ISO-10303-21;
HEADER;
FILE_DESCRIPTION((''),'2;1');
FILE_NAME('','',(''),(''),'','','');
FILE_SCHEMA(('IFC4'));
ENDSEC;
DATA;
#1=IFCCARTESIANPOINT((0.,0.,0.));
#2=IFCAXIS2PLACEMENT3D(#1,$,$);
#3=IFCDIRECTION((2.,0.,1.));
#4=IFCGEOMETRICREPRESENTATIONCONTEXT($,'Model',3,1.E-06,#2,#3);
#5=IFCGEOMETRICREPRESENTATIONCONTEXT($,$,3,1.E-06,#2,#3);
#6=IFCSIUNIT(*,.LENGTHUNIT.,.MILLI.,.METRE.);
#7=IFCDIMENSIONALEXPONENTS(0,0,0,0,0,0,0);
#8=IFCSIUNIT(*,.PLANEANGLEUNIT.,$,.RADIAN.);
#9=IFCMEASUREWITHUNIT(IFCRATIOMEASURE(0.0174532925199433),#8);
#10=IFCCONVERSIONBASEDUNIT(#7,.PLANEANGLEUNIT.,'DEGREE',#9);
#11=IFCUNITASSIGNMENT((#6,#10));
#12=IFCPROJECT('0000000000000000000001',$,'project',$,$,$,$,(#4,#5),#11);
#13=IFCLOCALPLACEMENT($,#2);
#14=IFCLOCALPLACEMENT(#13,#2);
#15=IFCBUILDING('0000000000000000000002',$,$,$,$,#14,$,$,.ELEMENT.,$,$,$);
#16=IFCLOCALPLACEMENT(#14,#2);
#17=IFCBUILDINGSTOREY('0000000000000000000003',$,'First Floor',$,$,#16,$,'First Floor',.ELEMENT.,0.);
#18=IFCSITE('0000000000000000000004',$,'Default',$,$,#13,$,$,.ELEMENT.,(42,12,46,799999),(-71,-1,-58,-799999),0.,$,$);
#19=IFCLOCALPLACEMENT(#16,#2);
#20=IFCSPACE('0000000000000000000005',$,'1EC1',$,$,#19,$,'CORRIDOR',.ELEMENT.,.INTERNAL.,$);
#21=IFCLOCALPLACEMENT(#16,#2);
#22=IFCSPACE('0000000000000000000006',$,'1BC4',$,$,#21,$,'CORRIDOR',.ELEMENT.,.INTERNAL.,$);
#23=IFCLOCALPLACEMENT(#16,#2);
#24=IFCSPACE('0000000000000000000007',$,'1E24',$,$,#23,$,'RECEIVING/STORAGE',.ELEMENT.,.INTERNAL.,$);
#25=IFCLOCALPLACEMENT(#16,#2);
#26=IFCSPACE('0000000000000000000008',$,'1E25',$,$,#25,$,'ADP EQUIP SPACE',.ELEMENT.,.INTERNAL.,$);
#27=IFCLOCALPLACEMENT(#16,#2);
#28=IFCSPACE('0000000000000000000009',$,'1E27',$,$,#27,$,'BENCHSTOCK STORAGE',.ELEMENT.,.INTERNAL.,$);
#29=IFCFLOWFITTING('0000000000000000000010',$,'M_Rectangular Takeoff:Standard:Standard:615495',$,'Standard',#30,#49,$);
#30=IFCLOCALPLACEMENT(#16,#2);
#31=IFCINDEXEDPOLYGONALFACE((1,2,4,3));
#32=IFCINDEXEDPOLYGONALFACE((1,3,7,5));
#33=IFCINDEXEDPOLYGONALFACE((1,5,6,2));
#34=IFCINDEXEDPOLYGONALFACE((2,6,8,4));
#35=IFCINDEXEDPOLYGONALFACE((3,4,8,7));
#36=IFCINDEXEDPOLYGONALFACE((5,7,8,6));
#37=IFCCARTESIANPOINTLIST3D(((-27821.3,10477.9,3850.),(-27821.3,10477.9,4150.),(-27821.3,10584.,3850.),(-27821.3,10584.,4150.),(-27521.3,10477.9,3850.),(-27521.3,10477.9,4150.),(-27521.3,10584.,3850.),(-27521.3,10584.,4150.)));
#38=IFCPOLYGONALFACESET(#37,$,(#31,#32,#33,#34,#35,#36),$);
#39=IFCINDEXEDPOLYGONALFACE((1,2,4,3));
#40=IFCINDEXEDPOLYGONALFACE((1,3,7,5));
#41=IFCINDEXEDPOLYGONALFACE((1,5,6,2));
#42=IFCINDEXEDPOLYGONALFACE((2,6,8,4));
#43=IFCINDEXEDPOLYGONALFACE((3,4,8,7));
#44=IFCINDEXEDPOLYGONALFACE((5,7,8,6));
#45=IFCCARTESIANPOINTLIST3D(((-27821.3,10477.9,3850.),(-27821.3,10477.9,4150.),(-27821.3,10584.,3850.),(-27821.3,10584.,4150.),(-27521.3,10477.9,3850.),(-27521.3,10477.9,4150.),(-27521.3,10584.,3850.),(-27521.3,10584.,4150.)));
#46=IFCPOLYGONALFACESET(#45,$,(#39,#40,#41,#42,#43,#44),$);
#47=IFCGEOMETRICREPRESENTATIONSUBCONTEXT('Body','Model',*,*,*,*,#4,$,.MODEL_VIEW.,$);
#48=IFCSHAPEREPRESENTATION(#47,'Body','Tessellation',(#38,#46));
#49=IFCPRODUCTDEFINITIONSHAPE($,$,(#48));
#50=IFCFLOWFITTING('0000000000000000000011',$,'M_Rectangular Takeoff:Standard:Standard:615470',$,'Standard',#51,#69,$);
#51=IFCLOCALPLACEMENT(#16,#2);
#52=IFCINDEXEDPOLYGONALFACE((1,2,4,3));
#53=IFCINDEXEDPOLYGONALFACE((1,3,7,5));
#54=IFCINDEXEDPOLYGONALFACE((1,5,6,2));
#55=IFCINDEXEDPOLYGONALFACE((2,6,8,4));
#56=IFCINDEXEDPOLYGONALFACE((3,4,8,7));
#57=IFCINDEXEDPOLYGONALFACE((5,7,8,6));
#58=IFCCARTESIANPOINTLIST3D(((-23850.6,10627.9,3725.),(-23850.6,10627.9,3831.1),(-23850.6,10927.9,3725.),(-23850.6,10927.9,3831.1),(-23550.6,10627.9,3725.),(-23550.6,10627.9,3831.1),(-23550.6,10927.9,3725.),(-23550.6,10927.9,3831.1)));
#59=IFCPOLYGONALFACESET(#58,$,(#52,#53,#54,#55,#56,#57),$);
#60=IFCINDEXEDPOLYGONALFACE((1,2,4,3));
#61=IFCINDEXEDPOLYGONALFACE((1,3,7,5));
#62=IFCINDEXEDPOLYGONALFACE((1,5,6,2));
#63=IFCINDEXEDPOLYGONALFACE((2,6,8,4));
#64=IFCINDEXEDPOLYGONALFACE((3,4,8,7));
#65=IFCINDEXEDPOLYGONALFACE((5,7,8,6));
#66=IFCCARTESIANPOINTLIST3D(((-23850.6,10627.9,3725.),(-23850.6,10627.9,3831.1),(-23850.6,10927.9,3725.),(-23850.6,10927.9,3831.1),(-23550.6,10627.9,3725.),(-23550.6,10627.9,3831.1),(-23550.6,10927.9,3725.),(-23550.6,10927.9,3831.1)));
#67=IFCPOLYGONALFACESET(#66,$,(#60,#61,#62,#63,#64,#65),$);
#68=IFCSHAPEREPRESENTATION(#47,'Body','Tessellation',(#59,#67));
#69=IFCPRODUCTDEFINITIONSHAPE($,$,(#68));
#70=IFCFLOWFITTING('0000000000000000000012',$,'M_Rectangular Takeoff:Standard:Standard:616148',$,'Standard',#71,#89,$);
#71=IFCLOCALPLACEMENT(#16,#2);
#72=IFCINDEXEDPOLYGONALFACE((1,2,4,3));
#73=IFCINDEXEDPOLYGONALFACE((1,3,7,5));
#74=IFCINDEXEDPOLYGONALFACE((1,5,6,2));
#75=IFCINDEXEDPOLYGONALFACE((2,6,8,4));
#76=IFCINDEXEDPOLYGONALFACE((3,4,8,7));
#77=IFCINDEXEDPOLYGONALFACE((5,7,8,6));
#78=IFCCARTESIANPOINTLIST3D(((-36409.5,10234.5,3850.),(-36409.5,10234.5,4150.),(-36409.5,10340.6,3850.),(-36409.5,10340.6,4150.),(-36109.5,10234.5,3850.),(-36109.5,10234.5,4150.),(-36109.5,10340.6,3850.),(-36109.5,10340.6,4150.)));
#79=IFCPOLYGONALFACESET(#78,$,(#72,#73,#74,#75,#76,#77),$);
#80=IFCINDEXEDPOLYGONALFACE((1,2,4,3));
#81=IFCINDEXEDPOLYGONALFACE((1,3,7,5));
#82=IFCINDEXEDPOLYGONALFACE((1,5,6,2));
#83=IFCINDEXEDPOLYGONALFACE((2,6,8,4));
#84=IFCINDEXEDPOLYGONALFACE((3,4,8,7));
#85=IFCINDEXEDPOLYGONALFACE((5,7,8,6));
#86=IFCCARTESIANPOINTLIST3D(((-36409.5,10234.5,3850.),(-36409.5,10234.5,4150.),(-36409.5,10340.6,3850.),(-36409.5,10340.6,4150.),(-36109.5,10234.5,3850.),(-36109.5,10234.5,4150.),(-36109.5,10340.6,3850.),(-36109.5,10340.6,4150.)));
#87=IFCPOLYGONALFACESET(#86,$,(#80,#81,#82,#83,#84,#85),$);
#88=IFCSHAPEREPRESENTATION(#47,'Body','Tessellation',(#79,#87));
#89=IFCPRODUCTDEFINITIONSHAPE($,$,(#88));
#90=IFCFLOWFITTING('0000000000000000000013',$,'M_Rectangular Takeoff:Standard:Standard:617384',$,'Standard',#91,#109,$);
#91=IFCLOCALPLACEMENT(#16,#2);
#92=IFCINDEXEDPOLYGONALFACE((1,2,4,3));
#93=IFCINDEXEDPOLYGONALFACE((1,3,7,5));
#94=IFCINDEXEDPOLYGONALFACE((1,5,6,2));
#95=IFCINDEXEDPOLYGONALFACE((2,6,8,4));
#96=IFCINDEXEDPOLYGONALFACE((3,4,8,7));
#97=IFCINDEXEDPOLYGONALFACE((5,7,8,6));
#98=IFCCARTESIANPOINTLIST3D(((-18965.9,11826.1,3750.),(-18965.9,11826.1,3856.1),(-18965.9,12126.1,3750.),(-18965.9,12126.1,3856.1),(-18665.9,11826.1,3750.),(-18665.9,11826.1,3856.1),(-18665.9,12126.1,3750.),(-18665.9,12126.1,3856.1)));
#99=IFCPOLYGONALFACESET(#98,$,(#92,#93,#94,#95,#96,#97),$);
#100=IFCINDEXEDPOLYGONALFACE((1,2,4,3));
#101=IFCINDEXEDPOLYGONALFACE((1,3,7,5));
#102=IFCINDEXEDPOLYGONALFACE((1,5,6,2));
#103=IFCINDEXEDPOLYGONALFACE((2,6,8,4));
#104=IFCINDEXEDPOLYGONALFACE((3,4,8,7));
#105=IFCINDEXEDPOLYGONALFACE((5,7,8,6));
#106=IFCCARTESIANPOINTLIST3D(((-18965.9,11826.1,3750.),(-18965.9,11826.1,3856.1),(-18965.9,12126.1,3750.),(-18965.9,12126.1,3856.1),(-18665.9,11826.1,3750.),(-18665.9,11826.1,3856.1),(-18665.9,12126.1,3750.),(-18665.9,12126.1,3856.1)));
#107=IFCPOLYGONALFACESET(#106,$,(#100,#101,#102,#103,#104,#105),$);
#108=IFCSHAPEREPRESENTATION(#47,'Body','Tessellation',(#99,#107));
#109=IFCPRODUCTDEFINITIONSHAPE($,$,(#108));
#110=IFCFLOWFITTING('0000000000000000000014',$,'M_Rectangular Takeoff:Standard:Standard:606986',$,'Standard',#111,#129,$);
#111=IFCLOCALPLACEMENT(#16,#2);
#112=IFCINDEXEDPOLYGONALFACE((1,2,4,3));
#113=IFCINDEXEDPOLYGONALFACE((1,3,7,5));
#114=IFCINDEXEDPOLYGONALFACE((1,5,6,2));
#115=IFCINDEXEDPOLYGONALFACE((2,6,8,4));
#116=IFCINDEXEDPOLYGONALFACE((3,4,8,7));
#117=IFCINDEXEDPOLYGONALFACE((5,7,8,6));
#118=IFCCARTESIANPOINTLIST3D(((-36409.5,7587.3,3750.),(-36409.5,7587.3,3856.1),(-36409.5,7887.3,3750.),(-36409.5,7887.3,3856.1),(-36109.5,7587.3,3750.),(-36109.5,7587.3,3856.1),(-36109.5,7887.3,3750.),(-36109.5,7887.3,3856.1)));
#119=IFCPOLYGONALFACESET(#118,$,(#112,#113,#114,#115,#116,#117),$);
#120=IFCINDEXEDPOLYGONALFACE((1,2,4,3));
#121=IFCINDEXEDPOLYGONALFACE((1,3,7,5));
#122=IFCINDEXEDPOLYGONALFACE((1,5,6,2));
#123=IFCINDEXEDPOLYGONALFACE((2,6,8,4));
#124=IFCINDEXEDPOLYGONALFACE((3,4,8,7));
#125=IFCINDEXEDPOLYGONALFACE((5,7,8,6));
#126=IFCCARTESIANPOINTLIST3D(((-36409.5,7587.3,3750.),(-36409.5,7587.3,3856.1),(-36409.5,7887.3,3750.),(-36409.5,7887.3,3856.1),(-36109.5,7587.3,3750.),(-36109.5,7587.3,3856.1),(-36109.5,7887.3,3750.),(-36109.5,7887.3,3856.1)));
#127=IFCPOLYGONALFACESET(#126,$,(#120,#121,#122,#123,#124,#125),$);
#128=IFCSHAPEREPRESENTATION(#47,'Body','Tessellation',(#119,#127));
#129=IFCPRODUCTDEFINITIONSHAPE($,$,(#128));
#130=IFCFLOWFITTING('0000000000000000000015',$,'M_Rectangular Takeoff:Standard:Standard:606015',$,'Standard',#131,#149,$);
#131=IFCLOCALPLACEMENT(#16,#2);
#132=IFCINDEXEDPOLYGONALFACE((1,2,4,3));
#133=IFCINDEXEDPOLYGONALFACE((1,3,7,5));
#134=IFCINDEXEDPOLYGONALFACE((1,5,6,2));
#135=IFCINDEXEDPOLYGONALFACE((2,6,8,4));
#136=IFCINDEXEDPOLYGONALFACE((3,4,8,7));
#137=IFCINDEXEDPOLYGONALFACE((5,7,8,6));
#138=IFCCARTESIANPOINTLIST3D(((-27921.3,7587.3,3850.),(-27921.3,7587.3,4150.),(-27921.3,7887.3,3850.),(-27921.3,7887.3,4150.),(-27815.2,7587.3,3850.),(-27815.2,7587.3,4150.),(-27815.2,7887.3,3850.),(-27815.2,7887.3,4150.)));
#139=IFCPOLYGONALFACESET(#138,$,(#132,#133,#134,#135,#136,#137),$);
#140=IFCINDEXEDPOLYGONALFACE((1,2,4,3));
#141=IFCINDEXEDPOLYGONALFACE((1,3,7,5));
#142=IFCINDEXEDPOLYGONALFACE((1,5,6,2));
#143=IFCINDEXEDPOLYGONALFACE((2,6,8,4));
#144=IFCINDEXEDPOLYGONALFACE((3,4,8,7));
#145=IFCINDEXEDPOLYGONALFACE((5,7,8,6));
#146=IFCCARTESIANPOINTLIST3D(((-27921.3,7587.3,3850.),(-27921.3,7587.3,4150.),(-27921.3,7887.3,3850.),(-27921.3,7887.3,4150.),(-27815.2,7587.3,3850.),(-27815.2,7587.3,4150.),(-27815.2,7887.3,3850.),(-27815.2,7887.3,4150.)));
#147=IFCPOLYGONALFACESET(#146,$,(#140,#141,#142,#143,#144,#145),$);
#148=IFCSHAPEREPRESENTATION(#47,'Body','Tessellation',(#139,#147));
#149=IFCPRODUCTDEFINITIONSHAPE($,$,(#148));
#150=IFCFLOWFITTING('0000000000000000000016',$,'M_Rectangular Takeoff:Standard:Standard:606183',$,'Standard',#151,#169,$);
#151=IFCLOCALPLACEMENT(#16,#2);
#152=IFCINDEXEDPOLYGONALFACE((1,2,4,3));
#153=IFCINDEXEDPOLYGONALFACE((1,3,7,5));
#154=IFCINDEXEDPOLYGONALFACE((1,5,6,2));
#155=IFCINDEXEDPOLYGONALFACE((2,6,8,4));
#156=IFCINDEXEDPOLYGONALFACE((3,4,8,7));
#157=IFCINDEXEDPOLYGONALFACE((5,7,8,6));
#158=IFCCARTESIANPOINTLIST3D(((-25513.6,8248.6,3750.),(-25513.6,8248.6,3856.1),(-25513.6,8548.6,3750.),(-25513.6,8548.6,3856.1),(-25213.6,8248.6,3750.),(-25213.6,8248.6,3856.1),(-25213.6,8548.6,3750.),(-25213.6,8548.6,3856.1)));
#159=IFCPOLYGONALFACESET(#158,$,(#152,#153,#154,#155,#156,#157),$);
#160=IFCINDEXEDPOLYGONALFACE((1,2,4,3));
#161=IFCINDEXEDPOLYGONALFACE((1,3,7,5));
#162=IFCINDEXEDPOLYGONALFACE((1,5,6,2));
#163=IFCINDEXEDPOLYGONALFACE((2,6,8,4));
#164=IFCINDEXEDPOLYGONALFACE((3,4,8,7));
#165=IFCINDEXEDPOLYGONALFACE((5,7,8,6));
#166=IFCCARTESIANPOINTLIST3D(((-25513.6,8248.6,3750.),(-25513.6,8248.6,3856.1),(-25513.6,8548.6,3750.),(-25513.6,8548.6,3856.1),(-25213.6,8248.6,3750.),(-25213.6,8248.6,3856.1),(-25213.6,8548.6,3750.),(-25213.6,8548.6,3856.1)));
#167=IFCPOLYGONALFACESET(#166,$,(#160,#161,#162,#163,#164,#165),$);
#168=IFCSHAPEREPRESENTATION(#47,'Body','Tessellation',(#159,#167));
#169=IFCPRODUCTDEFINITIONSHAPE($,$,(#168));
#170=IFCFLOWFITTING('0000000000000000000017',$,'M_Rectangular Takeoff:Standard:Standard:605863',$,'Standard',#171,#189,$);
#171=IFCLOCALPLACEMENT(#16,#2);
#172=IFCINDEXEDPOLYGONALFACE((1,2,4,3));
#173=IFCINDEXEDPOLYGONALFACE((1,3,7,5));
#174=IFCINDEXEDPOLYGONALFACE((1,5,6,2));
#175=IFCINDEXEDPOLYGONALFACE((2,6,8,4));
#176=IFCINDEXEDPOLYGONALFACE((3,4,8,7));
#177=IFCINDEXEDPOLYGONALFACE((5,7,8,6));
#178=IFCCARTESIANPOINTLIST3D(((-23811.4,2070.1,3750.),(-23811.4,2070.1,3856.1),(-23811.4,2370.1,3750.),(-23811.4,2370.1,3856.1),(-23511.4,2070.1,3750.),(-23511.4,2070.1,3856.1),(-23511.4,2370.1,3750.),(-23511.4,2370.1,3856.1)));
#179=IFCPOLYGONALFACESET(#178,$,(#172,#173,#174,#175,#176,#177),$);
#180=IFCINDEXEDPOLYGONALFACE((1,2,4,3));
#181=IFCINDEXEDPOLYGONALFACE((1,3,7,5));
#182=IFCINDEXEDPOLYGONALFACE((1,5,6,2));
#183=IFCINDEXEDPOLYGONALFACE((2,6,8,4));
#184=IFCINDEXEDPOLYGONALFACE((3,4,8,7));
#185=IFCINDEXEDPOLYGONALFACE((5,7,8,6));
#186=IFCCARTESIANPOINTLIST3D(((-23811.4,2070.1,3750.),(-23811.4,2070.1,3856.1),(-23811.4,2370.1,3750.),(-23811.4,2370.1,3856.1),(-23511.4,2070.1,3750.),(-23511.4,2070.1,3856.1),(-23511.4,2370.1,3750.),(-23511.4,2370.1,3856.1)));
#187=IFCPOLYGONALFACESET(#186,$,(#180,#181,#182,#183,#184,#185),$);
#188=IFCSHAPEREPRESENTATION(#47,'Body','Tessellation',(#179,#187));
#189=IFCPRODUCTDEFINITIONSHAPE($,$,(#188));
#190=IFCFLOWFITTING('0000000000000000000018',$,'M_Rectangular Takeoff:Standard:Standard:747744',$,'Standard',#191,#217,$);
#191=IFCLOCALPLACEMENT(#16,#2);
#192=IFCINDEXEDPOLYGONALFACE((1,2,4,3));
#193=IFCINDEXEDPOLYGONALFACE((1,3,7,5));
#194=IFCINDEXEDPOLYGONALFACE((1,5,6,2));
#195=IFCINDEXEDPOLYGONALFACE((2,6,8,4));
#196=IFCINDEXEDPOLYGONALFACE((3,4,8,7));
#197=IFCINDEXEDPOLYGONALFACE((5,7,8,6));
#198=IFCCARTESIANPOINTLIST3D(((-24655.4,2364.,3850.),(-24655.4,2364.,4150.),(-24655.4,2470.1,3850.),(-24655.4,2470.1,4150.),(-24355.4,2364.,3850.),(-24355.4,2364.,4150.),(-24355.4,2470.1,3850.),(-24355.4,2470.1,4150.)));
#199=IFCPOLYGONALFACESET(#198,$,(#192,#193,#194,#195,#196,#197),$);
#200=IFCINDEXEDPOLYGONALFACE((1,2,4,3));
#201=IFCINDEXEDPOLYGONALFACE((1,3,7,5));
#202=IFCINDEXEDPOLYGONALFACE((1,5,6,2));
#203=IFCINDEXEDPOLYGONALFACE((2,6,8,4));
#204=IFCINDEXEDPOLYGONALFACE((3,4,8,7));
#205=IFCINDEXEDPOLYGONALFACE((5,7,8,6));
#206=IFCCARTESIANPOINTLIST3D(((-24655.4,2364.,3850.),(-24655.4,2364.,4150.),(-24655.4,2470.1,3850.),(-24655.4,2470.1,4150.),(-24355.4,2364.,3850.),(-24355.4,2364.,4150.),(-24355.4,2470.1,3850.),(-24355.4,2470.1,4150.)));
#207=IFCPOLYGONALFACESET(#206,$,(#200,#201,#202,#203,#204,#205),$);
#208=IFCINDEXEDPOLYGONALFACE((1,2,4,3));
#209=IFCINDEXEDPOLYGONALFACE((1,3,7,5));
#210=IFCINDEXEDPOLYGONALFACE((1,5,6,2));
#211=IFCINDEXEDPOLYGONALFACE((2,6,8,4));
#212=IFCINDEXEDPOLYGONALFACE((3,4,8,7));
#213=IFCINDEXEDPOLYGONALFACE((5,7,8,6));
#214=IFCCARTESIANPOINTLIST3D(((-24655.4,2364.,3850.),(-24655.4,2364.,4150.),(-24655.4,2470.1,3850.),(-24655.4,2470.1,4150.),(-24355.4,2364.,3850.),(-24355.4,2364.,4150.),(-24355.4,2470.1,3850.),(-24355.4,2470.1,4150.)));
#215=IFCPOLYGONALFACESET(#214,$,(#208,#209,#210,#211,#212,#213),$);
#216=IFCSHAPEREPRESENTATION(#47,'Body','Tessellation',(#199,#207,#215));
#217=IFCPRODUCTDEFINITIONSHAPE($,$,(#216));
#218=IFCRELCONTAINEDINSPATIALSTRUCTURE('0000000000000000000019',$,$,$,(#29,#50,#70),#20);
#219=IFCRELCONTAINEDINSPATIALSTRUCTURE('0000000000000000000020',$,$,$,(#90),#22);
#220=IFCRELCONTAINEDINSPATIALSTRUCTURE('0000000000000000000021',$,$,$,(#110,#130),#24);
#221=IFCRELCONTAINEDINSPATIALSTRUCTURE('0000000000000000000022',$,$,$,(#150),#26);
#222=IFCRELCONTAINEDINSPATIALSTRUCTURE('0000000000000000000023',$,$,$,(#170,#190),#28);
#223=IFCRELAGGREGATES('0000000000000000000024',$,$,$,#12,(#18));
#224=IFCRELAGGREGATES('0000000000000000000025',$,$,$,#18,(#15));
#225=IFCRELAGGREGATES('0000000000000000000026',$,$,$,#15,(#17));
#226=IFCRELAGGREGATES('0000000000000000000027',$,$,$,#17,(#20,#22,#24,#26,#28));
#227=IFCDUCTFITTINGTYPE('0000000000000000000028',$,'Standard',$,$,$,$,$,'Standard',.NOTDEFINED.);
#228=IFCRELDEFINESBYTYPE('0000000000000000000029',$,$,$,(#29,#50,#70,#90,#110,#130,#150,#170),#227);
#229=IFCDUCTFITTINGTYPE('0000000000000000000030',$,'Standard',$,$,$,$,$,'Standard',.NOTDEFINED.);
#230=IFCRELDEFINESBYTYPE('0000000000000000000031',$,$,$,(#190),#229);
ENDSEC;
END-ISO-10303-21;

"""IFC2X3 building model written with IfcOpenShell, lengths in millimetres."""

from ifc_helpers import new_model, entity, si_unit, converted_unit, direction, frame, frame_2d, origin, place, context, subcontext, project, spatial, rectangle, extrude, source, transform, mapped, type_object, type_shapes, element, save


model = new_model("IFC2X3")

# Units and contexts
model_context = context("Model", 3, precision=1e-06, world=origin(), true_north=direction((2.0, 0.0, 1.0)))
context_of_model = context(None, 3, precision=1e-06, world=origin(), true_north=direction((2.0, 0.0, 1.0)))
body_context = subcontext(model_context, "Body", "Model", "MODEL_VIEW")
ifc_project = project(units=[si_unit("LENGTHUNIT", "METRE", prefix="MILLI"), converted_unit("PLANEANGLEUNIT", "DEGREE", entity("IfcRatioMeasure", 0.0174532925199433), si_unit("PLANEANGLEUNIT", "RADIAN"), dimensions=[0, 0, 0, 0, 0, 0, 0])], contexts=[model_context, context_of_model])

# Site, building, storey
site_placement = place(None, origin())
site = spatial("IfcSite", under=ifc_project, at=site_placement, Name="Default", CompositionType="ELEMENT", RefLatitude=(42, 12, 46, 799999), RefLongitude=(-71, -1, -58, -799999), RefElevation=0.0)
building_placement = place(site_placement, origin())
building = spatial("IfcBuilding", under=site, at=building_placement, CompositionType="ELEMENT")
storey_placement = place(building_placement, origin())
storey = spatial("IfcBuildingStorey", under=building, at=storey_placement, Name="First Floor", LongName="First Floor", CompositionType="ELEMENT", Elevation=0.0)

# Shared definitions
space_1_placement = place(storey_placement, origin())
space_1 = spatial("IfcSpace", under=storey, at=space_1_placement, Name="1EC1", LongName="CORRIDOR", CompositionType="ELEMENT", InteriorOrExteriorSpace="INTERNAL")

# Flow fittings
duct_fitting_type_1 = type_object("IfcDuctFittingType", Name="Standard", ElementType="Standard", PredefinedType="NOTDEFINED")
shared_shape_1 = source(origin(), body_context, "Body", "SweptSolid", [
    extrude(rectangle(XDim=300.0, YDim=106.1, at=frame_2d((0.0, 0.0), x_axis=(1.0, 0.0))), frame((47.0, 0.0, -150.0), z_axis=(0.0, 0.0, 1.0), x_axis=(0.0, -1.0, 0.0)), (0.0, 0.0, 1.0), 300.0),
    extrude(rectangle(XDim=300.0, YDim=106.1, at=frame_2d((0.0, 0.0), x_axis=(1.0, 0.0))), frame((47.0, 0.0, -150.0), z_axis=(0.0, 0.0, 1.0), x_axis=(0.0, -1.0, 0.0)), (0.0, 0.0, 1.0), 300.0),
])
type_shapes(duct_fitting_type_1, [shared_shape_1])
for number, where, z_axis, x_axis, name in (
    (1, (-27671.3, 10577.9, 4000.0), (0.0, 0.0, -1.0), (0.0, -1.0, 0.0), "M_Rectangular Takeoff:Standard:Standard:615495"),
    (2, (-23700.6, 10777.9, 3825.0), (1.0, 0.0, 0.0), (0.0, 0.0, -1.0), "M_Rectangular Takeoff:Standard:Standard:615470"),
    (3, (-36259.5, 10334.5, 4000.0), (0.0, 0.0, -1.0), (0.0, -1.0, 0.0), "M_Rectangular Takeoff:Standard:Standard:616148"),
):
    element("IfcFlowFitting", number, at=place(space_1_placement, frame(where, z_axis=z_axis, x_axis=x_axis)), inside=space_1, type_object=duct_fitting_type_1, Name=name, ObjectType="Standard", context=body_context, shape_type="MappedRepresentation", body=[
        mapped(shared_shape_1, transform((0.0, 0.0, 0.0), scale=1.0)),
    ])

# Shared definitions
space_2_placement = place(storey_placement, origin())
space_2 = spatial("IfcSpace", under=storey, at=space_2_placement, Name="1BC4", LongName="CORRIDOR", CompositionType="ELEMENT", InteriorOrExteriorSpace="INTERNAL")

# Flow fitting
flow_fitting_1_placement = place(space_2_placement, frame((-18815.9, 11976.1, 3850.0), z_axis=(0.0, 1.0, 0.0), x_axis=(0.0, 0.0, -1.0)))
element("IfcFlowFitting", 4, at=flow_fitting_1_placement, inside=space_2, type_object=duct_fitting_type_1, Name="M_Rectangular Takeoff:Standard:Standard:617384", ObjectType="Standard", context=body_context, shape_type="MappedRepresentation", body=[
    mapped(shared_shape_1, transform((0.0, 0.0, 0.0), scale=1.0)),
])

# Shared definitions
space_3_placement = place(storey_placement, origin())
space_3 = spatial("IfcSpace", under=storey, at=space_3_placement, Name="1E24", LongName="RECEIVING/STORAGE", CompositionType="ELEMENT", InteriorOrExteriorSpace="INTERNAL")

# Flow fittings
for number, where, z_axis, x_axis, name in (
    (5, (-36259.5, 7737.3, 3850.0), (0.0, -1.0, 0.0), (0.0, 0.0, -1.0), "M_Rectangular Takeoff:Standard:Standard:606986"),
    (6, (-27821.3, 7737.3, 4000.0), (0.0, 0.0, -1.0), (-1.0, 0.0, 0.0), "M_Rectangular Takeoff:Standard:Standard:606015"),
):
    element("IfcFlowFitting", number, at=place(space_3_placement, frame(where, z_axis=z_axis, x_axis=x_axis)), inside=space_3, type_object=duct_fitting_type_1, Name=name, ObjectType="Standard", context=body_context, shape_type="MappedRepresentation", body=[
        mapped(shared_shape_1, transform((0.0, 0.0, 0.0), scale=1.0)),
    ])

# Shared definitions
space_4_placement = place(storey_placement, origin())
space_4 = spatial("IfcSpace", under=storey, at=space_4_placement, Name="1E25", LongName="ADP EQUIP SPACE", CompositionType="ELEMENT", InteriorOrExteriorSpace="INTERNAL")

# Flow fitting
flow_fitting_2_placement = place(space_4_placement, frame((-25363.6, 8398.6, 3850.0), z_axis=(1.0, 0.0, 0.0), x_axis=(0.0, 0.0, -1.0)))
element("IfcFlowFitting", 7, at=flow_fitting_2_placement, inside=space_4, type_object=duct_fitting_type_1, Name="M_Rectangular Takeoff:Standard:Standard:606183", ObjectType="Standard", context=body_context, shape_type="MappedRepresentation", body=[
    mapped(shared_shape_1, transform((0.0, 0.0, 0.0), scale=1.0)),
])

# Shared definitions
space_5_placement = place(storey_placement, origin())
space_5 = spatial("IfcSpace", under=storey, at=space_5_placement, Name="1E27", LongName="BENCHSTOCK STORAGE", CompositionType="ELEMENT", InteriorOrExteriorSpace="INTERNAL")

# Flow fittings
flow_fitting_3_placement = place(space_5_placement, frame((-23661.4, 2220.1, 3850.0), z_axis=(1.0, 0.0, 0.0), x_axis=(0.0, 0.0, -1.0)))
element("IfcFlowFitting", 8, at=flow_fitting_3_placement, inside=space_5, type_object=duct_fitting_type_1, Name="M_Rectangular Takeoff:Standard:Standard:605863", ObjectType="Standard", context=body_context, shape_type="MappedRepresentation", body=[
    mapped(shared_shape_1, transform((0.0, 0.0, 0.0), scale=1.0)),
])
duct_fitting_type_2 = type_object("IfcDuctFittingType", Name="Standard", ElementType="Standard", PredefinedType="NOTDEFINED")
shared_shape_2 = source(origin(), body_context, "Body", "SweptSolid", [
    extrude(rectangle(XDim=106.1, YDim=300.0, at=frame_2d((0.0, 0.0), x_axis=(1.0, 0.0))), frame((47.0, 0.0, -150.0)), (0.0, 0.0, 1.0), 300.0),
    extrude(rectangle(XDim=106.1, YDim=300.0, at=frame_2d((0.0, 0.0), x_axis=(1.0, 0.0))), frame((47.0, 0.0, -150.0)), (0.0, 0.0, 1.0), 300.0),
    extrude(rectangle(XDim=106.1, YDim=300.0, at=frame_2d((0.0, 0.0), x_axis=(1.0, 0.0))), frame((47.0, 0.0, -150.0)), (0.0, 0.0, 1.0), 300.0),
])
type_shapes(duct_fitting_type_2, [shared_shape_2])
flow_fitting_4_placement = place(space_5_placement, frame((-24505.4, 2370.1, 4000.0), z_axis=(0.0, 0.0, -1.0), x_axis=(0.0, 1.0, 0.0)))
element("IfcFlowFitting", 9, at=flow_fitting_4_placement, inside=space_5, type_object=duct_fitting_type_2, Name="M_Rectangular Takeoff:Standard:Standard:747744", ObjectType="Standard", context=body_context, shape_type="MappedRepresentation", body=[
    mapped(shared_shape_2, transform((0.0, 0.0, 0.0), scale=1.0)),
])

save(model, "model.ifc")
